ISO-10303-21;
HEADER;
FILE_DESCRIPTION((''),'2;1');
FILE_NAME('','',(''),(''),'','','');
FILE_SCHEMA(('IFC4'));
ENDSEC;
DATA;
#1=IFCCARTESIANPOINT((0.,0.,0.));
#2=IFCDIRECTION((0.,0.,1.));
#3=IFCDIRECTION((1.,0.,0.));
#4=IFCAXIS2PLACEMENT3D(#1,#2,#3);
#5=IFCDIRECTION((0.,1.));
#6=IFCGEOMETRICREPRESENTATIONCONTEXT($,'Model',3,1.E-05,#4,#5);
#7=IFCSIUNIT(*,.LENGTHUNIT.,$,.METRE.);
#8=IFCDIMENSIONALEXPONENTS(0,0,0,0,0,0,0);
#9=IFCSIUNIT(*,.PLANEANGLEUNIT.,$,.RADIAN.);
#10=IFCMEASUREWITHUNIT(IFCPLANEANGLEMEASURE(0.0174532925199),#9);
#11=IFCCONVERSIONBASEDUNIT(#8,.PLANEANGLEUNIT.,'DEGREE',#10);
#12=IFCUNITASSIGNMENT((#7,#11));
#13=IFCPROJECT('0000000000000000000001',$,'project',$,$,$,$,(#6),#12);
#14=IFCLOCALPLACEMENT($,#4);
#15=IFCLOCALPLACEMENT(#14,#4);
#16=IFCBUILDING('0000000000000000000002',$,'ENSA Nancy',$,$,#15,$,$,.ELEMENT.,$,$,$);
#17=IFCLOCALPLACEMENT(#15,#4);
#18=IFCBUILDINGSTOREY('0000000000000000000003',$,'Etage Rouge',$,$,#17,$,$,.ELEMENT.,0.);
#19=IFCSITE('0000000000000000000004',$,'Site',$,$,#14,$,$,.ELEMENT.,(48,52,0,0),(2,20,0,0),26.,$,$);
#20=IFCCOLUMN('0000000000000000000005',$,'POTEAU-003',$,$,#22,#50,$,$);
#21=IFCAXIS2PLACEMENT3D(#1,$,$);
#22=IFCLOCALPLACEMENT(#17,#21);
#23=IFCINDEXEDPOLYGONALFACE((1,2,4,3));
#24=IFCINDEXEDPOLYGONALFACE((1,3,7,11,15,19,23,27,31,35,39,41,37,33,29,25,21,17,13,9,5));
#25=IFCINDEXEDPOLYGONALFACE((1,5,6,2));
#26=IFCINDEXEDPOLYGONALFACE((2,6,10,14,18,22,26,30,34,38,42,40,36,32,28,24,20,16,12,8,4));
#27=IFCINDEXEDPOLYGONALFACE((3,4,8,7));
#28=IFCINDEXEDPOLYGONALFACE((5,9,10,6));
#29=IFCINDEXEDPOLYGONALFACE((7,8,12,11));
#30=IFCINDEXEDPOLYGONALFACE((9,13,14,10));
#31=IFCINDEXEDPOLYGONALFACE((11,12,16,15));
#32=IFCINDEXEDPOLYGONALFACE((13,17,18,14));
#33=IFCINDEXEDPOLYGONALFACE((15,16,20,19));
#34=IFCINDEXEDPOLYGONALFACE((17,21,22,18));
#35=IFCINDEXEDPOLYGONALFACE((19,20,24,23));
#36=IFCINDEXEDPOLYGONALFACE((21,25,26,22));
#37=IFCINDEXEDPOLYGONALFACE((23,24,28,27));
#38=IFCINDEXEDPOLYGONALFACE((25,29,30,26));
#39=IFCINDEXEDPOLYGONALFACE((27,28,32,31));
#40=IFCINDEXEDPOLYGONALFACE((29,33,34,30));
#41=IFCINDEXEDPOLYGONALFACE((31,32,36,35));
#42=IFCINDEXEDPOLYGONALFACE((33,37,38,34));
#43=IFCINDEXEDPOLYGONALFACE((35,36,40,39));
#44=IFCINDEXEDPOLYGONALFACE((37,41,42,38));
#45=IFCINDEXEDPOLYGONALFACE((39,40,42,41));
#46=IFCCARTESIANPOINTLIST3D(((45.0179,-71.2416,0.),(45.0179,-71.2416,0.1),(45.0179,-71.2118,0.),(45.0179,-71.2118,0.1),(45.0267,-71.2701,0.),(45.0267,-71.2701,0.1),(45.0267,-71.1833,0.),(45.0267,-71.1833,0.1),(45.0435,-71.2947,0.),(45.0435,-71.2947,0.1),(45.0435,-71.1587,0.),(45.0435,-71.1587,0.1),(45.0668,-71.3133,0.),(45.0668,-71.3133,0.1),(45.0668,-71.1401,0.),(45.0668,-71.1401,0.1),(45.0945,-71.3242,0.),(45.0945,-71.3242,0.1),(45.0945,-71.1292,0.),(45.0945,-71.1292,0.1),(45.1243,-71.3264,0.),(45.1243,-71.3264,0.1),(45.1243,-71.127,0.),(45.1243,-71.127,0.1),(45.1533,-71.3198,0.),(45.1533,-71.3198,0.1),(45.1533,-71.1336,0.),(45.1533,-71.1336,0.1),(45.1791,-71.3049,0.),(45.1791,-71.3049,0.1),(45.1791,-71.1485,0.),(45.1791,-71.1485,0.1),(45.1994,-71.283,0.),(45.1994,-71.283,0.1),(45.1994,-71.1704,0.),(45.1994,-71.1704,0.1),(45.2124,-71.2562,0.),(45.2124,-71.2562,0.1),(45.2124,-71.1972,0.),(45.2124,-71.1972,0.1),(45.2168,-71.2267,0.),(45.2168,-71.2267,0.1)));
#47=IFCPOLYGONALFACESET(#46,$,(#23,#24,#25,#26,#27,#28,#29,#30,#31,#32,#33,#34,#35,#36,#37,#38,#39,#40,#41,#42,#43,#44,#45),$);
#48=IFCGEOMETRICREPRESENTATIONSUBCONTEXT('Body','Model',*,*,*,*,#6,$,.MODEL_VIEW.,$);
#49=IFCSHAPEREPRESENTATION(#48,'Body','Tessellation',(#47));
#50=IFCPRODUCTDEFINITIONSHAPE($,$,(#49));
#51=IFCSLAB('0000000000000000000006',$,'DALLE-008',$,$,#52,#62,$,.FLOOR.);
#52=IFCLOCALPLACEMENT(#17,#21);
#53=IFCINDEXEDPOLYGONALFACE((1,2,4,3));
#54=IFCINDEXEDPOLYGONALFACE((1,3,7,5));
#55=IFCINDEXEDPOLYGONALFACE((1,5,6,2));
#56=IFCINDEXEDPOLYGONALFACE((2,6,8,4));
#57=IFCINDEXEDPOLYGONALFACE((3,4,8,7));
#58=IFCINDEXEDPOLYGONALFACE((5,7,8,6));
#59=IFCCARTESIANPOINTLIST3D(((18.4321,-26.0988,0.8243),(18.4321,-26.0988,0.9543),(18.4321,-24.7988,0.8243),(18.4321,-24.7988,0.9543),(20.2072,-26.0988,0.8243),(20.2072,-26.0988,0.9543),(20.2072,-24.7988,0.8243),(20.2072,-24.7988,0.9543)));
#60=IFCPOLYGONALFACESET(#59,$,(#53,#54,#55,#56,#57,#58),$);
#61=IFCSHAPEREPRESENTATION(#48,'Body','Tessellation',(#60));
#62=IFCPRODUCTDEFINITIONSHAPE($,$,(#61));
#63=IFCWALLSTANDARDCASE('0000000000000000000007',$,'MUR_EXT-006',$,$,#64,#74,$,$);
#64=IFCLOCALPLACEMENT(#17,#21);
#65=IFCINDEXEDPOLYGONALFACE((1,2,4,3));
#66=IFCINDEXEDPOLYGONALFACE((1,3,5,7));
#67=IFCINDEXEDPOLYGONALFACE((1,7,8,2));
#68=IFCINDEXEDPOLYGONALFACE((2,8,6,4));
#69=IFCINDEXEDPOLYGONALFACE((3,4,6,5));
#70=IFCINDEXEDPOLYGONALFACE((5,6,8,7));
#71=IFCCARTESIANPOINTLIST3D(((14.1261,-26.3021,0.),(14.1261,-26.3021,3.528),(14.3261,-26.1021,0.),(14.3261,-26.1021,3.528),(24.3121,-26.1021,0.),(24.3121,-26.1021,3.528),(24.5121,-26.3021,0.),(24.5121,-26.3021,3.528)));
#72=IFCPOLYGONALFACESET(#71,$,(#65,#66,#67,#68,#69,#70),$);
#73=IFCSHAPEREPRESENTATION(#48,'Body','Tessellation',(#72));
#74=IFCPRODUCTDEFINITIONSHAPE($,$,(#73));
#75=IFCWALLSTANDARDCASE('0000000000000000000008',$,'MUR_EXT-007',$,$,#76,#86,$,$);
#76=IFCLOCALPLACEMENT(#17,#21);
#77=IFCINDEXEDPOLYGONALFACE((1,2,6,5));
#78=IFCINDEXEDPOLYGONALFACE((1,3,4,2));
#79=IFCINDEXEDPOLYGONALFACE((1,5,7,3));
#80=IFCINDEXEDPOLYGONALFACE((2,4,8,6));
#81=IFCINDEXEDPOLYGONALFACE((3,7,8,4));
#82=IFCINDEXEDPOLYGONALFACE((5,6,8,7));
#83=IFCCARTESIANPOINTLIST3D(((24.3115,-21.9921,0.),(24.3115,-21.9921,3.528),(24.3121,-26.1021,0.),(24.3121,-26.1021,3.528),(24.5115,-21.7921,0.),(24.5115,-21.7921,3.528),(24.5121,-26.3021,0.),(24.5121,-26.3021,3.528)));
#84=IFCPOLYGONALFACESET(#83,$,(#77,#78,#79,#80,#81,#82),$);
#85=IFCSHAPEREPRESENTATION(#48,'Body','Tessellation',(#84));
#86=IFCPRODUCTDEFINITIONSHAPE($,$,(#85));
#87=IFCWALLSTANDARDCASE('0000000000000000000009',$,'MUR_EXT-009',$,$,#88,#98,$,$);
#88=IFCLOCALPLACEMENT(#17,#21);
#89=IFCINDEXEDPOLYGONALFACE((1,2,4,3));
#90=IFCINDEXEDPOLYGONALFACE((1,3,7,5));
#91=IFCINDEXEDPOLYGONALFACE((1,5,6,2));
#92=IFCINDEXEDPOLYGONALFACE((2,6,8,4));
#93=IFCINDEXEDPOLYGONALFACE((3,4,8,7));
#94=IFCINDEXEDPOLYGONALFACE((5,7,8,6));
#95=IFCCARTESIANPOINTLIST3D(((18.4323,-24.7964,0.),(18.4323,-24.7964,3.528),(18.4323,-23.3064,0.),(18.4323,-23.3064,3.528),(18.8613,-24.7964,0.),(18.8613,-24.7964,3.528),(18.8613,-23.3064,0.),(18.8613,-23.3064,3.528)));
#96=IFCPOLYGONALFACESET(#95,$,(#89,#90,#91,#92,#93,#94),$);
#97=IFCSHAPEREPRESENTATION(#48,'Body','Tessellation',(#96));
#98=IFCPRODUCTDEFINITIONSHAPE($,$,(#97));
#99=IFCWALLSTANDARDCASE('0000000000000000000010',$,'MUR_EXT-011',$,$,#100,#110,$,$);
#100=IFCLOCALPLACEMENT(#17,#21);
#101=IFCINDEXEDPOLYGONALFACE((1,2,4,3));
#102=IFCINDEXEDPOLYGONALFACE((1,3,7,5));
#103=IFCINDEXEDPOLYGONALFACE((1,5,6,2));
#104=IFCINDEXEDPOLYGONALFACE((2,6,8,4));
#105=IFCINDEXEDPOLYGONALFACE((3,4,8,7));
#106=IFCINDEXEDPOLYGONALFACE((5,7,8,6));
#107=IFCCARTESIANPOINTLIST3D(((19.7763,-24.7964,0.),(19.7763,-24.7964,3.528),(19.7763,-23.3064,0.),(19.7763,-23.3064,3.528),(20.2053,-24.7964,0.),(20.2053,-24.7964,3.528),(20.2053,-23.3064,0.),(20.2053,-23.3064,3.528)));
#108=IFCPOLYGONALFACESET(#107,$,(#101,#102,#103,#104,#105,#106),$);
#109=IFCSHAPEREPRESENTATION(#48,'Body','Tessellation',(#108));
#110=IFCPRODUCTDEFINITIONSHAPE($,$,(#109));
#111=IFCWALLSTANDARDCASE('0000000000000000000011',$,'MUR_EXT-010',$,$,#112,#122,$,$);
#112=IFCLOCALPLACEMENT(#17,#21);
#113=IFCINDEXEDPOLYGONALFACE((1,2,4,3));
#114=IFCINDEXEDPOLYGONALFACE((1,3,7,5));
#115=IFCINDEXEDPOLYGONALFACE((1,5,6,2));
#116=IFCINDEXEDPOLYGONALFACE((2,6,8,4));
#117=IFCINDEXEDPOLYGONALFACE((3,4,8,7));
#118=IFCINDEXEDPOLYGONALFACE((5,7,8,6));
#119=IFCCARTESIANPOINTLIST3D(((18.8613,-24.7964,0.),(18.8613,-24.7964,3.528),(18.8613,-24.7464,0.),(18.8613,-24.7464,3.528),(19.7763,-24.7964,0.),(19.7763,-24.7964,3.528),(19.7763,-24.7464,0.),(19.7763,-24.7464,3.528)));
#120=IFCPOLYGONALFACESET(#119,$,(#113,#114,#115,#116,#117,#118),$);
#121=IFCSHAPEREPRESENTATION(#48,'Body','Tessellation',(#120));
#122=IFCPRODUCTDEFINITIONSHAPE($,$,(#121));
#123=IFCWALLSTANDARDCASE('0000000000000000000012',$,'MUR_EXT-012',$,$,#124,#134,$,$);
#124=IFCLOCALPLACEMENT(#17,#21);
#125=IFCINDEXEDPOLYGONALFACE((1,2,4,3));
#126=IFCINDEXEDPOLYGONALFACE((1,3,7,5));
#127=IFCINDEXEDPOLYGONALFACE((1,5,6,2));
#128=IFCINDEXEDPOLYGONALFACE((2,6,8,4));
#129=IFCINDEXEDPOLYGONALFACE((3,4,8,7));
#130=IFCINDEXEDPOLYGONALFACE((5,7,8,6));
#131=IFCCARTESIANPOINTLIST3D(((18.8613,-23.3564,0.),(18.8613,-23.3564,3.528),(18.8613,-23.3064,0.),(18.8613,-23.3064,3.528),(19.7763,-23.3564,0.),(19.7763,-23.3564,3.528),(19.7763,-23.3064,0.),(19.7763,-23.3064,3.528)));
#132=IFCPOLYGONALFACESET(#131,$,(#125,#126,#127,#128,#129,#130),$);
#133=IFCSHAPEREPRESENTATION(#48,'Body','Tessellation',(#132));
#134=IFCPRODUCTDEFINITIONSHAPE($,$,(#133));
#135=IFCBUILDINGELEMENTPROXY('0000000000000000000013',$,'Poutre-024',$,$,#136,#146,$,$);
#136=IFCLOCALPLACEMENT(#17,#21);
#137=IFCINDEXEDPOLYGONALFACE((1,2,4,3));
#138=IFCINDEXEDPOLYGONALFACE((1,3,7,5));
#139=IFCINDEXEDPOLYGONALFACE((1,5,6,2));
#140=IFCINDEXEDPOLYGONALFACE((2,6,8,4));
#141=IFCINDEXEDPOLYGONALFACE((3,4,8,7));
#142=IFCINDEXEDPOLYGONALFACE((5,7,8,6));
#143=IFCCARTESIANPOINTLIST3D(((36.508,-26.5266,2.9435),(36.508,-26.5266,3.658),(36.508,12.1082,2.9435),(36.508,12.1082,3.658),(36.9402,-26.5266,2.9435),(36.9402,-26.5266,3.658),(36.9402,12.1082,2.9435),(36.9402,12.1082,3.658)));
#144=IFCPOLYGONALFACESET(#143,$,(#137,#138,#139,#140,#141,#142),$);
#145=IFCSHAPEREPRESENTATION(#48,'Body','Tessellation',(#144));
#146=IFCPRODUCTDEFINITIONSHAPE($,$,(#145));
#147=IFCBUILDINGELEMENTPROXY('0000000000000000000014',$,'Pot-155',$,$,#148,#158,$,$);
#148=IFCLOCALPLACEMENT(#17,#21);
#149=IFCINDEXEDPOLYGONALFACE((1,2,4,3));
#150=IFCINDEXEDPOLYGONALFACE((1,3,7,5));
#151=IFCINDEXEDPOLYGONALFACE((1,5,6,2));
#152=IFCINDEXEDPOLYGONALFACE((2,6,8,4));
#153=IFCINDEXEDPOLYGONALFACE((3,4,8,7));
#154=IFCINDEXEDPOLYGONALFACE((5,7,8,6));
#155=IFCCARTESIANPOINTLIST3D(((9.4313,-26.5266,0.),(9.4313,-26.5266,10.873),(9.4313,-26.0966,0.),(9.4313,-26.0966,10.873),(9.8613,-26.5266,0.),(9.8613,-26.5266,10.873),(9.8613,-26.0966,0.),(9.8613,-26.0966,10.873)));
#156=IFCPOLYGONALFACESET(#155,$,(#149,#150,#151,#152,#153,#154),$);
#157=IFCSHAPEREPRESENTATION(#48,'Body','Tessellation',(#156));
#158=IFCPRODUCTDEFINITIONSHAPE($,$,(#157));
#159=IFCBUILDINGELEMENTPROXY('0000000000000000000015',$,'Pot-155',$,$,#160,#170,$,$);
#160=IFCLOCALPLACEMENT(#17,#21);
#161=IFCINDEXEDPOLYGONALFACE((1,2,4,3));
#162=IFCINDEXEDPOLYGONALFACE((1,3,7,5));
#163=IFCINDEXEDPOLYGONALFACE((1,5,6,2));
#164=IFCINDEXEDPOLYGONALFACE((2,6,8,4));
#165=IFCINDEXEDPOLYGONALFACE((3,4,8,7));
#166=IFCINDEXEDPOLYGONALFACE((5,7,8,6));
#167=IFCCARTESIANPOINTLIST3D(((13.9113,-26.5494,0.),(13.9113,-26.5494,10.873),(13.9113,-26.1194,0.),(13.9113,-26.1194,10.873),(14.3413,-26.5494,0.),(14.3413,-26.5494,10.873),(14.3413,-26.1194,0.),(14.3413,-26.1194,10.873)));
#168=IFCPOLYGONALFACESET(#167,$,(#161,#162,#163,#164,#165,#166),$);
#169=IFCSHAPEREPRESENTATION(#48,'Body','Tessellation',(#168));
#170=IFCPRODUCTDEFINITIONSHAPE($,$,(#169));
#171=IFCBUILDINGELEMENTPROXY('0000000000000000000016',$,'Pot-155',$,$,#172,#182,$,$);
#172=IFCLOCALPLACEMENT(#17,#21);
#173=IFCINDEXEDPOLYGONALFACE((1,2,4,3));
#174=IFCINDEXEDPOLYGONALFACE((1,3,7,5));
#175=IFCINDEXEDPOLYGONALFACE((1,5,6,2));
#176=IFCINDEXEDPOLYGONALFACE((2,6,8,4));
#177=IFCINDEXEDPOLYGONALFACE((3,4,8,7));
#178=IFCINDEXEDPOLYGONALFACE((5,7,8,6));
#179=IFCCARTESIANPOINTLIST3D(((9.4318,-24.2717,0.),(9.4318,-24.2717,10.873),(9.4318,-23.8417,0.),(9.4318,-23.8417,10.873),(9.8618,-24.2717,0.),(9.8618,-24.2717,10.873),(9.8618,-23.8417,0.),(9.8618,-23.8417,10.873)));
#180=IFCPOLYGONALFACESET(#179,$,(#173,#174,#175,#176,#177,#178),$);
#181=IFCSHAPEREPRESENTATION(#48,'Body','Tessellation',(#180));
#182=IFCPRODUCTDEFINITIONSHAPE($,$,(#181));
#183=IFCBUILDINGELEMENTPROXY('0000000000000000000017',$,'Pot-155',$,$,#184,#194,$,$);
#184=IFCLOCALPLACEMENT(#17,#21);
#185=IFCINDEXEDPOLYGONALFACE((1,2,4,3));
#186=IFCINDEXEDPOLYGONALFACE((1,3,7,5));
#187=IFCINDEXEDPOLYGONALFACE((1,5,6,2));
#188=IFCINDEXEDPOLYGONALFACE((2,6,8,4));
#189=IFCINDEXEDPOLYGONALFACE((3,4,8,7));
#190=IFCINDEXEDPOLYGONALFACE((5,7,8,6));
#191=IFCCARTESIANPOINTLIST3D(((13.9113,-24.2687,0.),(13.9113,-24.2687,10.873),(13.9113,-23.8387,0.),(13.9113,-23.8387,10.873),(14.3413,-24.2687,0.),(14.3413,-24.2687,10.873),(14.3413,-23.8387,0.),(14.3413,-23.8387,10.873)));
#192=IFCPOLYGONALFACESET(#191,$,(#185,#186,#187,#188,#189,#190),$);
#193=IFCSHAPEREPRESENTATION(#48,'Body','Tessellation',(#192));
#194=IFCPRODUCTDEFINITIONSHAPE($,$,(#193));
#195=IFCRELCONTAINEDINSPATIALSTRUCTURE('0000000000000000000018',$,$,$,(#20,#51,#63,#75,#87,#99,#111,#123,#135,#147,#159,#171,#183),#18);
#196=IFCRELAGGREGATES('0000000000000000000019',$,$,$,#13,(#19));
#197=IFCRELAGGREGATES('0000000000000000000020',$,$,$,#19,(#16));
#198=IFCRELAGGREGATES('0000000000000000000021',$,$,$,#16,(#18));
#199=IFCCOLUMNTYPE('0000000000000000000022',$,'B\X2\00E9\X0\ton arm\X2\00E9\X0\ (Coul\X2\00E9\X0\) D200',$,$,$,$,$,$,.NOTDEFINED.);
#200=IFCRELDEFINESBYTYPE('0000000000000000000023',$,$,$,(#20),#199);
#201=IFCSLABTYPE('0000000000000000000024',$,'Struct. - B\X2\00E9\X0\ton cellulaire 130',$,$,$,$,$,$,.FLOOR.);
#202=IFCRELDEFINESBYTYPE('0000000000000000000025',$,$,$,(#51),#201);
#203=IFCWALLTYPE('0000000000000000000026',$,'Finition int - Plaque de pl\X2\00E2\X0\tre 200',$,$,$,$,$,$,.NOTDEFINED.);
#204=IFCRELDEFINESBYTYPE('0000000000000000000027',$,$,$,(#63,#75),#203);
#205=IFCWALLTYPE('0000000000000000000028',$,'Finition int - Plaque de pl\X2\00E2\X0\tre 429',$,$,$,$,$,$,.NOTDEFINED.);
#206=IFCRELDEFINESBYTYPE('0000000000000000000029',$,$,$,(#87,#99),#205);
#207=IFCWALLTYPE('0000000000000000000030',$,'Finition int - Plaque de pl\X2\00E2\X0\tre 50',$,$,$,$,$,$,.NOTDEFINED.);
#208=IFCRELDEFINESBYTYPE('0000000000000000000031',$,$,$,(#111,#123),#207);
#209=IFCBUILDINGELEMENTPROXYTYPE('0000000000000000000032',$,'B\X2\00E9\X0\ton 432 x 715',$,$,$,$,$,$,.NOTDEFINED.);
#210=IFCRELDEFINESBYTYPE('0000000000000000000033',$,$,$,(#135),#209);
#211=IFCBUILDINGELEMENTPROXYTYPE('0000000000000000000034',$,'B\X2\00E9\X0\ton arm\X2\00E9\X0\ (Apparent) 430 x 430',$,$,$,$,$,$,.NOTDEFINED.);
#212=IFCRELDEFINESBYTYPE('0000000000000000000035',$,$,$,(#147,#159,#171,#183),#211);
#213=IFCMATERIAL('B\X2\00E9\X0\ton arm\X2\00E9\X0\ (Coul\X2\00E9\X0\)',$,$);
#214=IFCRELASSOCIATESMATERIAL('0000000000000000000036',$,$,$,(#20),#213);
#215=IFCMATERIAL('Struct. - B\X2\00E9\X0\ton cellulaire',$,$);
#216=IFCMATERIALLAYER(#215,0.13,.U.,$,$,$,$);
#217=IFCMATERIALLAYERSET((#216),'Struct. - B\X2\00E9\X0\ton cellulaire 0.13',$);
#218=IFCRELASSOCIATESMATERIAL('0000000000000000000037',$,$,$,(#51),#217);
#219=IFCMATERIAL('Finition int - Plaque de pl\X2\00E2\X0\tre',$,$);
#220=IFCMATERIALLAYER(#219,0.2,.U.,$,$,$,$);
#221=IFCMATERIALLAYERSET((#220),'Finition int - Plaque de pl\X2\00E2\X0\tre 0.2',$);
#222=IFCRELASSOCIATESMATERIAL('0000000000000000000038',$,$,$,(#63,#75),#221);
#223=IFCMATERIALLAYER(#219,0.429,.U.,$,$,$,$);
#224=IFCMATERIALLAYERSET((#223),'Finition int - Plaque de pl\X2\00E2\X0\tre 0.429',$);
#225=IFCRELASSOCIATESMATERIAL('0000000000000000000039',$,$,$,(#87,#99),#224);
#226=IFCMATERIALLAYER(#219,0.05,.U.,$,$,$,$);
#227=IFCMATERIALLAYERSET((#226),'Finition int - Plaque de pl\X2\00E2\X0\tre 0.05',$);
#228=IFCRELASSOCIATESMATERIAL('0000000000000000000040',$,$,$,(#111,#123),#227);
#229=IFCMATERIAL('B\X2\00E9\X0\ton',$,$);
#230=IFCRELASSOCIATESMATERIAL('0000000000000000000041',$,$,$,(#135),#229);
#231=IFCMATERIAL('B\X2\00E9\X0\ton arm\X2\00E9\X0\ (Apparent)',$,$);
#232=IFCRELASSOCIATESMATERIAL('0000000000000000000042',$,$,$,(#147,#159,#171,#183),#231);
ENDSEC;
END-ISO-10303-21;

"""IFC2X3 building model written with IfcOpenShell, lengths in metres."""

from ifc_helpers import new_model, entity, si_unit, converted_unit, direction, frame, frame_2d, origin_with_axes, origin_2d_with_axis, place, context, subcontext, project, spatial, polyline, rectangle, circle, outline, extrude, material, layer, layer_set, layer_usage, type_object, element, save


model = new_model("IFC2X3")

# Units and contexts
model_context = context("Model", 3, precision=1e-05, world=origin_with_axes(), true_north=direction((0.0, 1.0)))
body_context = subcontext(model_context, "Body", "Model", "MODEL_VIEW")
ifc_project = project(units=[si_unit("LENGTHUNIT", "METRE"), converted_unit("PLANEANGLEUNIT", "DEGREE", entity("IfcPlaneAngleMeasure", 0.0174532925199), si_unit("PLANEANGLEUNIT", "RADIAN"), dimensions=[0, 0, 0, 0, 0, 0, 0])], contexts=[model_context])

# Site, building, storey
site_placement = place(None, origin_with_axes())
site = spatial("IfcSite", under=ifc_project, at=site_placement, Name="Site", CompositionType="ELEMENT", RefLatitude=(48, 52, 0, 0), RefLongitude=(2, 20, 0, 0), RefElevation=26.0)
building_placement = place(site_placement, origin_with_axes())
building = spatial("IfcBuilding", under=site, at=building_placement, Name="ENSA Nancy", CompositionType="ELEMENT")
storey_placement = place(building_placement, origin_with_axes())
storey = spatial("IfcBuildingStorey", under=building, at=storey_placement, Name="Etage Rouge", CompositionType="ELEMENT", Elevation=0.0)

# Column
ifc_material_1 = material(Name="Béton armé (Coulé)")
column_type = type_object("IfcColumnType", Name="Béton armé (Coulé) D200", PredefinedType="NOTDEFINED")
column_placement = place(storey_placement, frame((45.1168, -71.2267, 0.0), z_axis=(0.0, 0.0, 1.0), x_axis=(1.0, 0.0, 0.0)))
element("IfcColumn", 1, at=column_placement, inside=storey, type_object=column_type, material=ifc_material_1, Name="POTEAU-003", context=body_context, shape_type="SweptSolid", body=[
    extrude(circle(Radius=0.1, at=origin_2d_with_axis()), origin_with_axes(), (0.0, 0.0, 1.0), 0.1),
])

# Slab
ifc_material_2 = material(Name="Struct. - Béton cellulaire")
ifc_layer_1 = layer(ifc_material_2, 0.13, ventilated="UNKNOWN")
ifc_layer_set_1 = layer_set([ifc_layer_1], Name="Struct. - Béton cellulaire 0.13")
ifc_layer_usage_1 = layer_usage(ifc_layer_set_1, "AXIS3", "NEGATIVE", 0.13)
slab_type = type_object("IfcSlabType", Name="Struct. - Béton cellulaire 130", PredefinedType="FLOOR")
slab_placement = place(storey_placement, frame((18.4321, -26.0988, 0.9543), z_axis=(0.0, 0.0, 1.0), x_axis=(1.0, 0.0, 0.0)))
element("IfcSlab", 2, at=slab_placement, inside=storey, type_object=slab_type, material=ifc_layer_usage_1, Name="DALLE-008", PredefinedType="FLOOR", context=body_context, shape_type="SweptSolid", body=[
    extrude(outline(polyline([(0.0, 0.0), (1.7751, 0.0), (1.7751, 1.3), (0.0, 1.3), (0.0, 0.0)])), frame((0.0, 0.0, -0.13), z_axis=(0.0, 0.0, 1.0), x_axis=(1.0, 0.0, 0.0)), (0.0, 0.0, 1.0), 0.13),
])

# Walls
ifc_material_3 = material(Name="Finition int - Plaque de plâtre")
ifc_layer_2 = layer(ifc_material_3, 0.2, ventilated="UNKNOWN")
ifc_layer_set_2 = layer_set([ifc_layer_2], Name="Finition int - Plaque de plâtre 0.2")
ifc_layer_usage_2 = layer_usage(ifc_layer_set_2, "AXIS2", "POSITIVE", 0.0)
wall_type_1 = type_object("IfcWallType", Name="Finition int - Plaque de plâtre 200", PredefinedType="NOTDEFINED")
wall_1_placement = place(storey_placement, frame((14.1261, -26.3021, 0.0), z_axis=(0.0, 0.0, 1.0), x_axis=(1.0, 0.000003, 0.0)))
element("IfcWallStandardCase", 3, at=wall_1_placement, inside=storey, type_object=wall_type_1, material=ifc_layer_usage_2, Name="MUR_EXT-006", context=body_context, shape_type="SweptSolid", body=[
    extrude(outline(polyline([(0.0, 0.0), (10.386, 0.0), (10.186, 0.2), (0.2, 0.2), (0.0, 0.0)])), origin_with_axes(), (0.0, 0.0, 1.0), 3.528),
])
ifc_layer_usage_3 = layer_usage(ifc_layer_set_2, "AXIS2", "POSITIVE", 0.0)
wall_2_placement = place(storey_placement, frame((24.5121, -26.3021, 0.0), z_axis=(0.0, 0.0, 1.0), x_axis=(-0.00015, 1.0, 0.0)))
element("IfcWallStandardCase", 4, at=wall_2_placement, inside=storey, type_object=wall_type_1, material=ifc_layer_usage_3, Name="MUR_EXT-007", context=body_context, shape_type="SweptSolid", body=[
    extrude(outline(polyline([(0.0, 0.0), (4.51, 0.0), (4.31, 0.2), (0.2, 0.2), (0.0, 0.0)])), origin_with_axes(), (0.0, 0.0, 1.0), 3.528),
])
ifc_layer_3 = layer(ifc_material_3, 0.429, ventilated="UNKNOWN")
ifc_layer_set_3 = layer_set([ifc_layer_3], Name="Finition int - Plaque de plâtre 0.429")
ifc_layer_usage_4 = layer_usage(ifc_layer_set_3, "AXIS2", "POSITIVE", -0.429)
wall_type_2 = type_object("IfcWallType", Name="Finition int - Plaque de plâtre 429", PredefinedType="NOTDEFINED")
wall_3_placement = place(storey_placement, frame((18.8613, -23.3064, 0.0), z_axis=(0.0, 0.0, 1.0), x_axis=(0.0, -1.0, 0.0)))
element("IfcWallStandardCase", 5, at=wall_3_placement, inside=storey, type_object=wall_type_2, material=ifc_layer_usage_4, Name="MUR_EXT-009", context=body_context, shape_type="SweptSolid", body=[
    extrude(outline(polyline([(0.0, -0.429), (1.49, -0.429), (1.49, 0.0), (0.0, 0.0), (0.0, -0.429)])), origin_with_axes(), (0.0, 0.0, 1.0), 3.528),
])
ifc_layer_usage_5 = layer_usage(ifc_layer_set_3, "AXIS2", "POSITIVE", -0.429)
wall_4_placement = place(storey_placement, frame((19.7763, -24.7964, 0.0), z_axis=(0.0, 0.0, 1.0), x_axis=(0.0, 1.0, 0.0)))
element("IfcWallStandardCase", 6, at=wall_4_placement, inside=storey, type_object=wall_type_2, material=ifc_layer_usage_5, Name="MUR_EXT-011", context=body_context, shape_type="SweptSolid", body=[
    extrude(outline(polyline([(0.0, -0.429), (1.49, -0.429), (1.49, 0.0), (0.0, 0.0), (0.0, -0.429)])), origin_with_axes(), (0.0, 0.0, 1.0), 3.528),
])
ifc_layer_4 = layer(ifc_material_3, 0.05, ventilated="UNKNOWN")
ifc_layer_set_4 = layer_set([ifc_layer_4], Name="Finition int - Plaque de plâtre 0.05")
ifc_layer_usage_6 = layer_usage(ifc_layer_set_4, "AXIS2", "POSITIVE", -0.05)
wall_type_3 = type_object("IfcWallType", Name="Finition int - Plaque de plâtre 50", PredefinedType="NOTDEFINED")
wall_5_placement = place(storey_placement, frame((18.8613, -24.7464, 0.0), z_axis=(0.0, 0.0, 1.0), x_axis=(1.0, 0.0, 0.0)))
element("IfcWallStandardCase", 7, at=wall_5_placement, inside=storey, type_object=wall_type_3, material=ifc_layer_usage_6, Name="MUR_EXT-010", context=body_context, shape_type="SweptSolid", body=[
    extrude(outline(polyline([(0.0, -0.05), (0.915, -0.05), (0.915, 0.0), (0.0, 0.0), (0.0, -0.05)])), origin_with_axes(), (0.0, 0.0, 1.0), 3.528),
])
ifc_layer_usage_7 = layer_usage(ifc_layer_set_4, "AXIS2", "POSITIVE", -0.05)
wall_6_placement = place(storey_placement, frame((19.7763, -23.3564, 0.0), z_axis=(0.0, 0.0, 1.0), x_axis=(-1.0, 0.0, 0.0)))
element("IfcWallStandardCase", 8, at=wall_6_placement, inside=storey, type_object=wall_type_3, material=ifc_layer_usage_7, Name="MUR_EXT-012", context=body_context, shape_type="SweptSolid", body=[
    extrude(outline(polyline([(0.0, -0.05), (0.915, -0.05), (0.915, 0.0), (0.0, 0.0), (0.0, -0.05)])), origin_with_axes(), (0.0, 0.0, 1.0), 3.528),
])

# Building element proxies
ifc_material_4 = material(Name="Béton")
building_element_proxy_type_1 = type_object("IfcBuildingElementProxyType", Name="Béton 432 x 715", PredefinedType="NOTDEFINED")
proxy_1_placement = place(storey_placement, frame((36.7241, -26.5266, 3.658), z_axis=(0.0, 0.0, 1.0), x_axis=(1.0, 0.0, 0.0)))
element("IfcBuildingElementProxy", 9, at=proxy_1_placement, inside=storey, type_object=building_element_proxy_type_1, material=ifc_material_4, Name="Poutre-024", context=body_context, shape_type="SweptSolid", body=[
    extrude(rectangle(XDim=0.7145, YDim=0.4321, at=frame_2d((-0.3573, 0.0), x_axis=(1.0, 0.0))), frame((0.0, 0.0, 0.0), z_axis=(0.0, 1.0, 0.0), x_axis=(0.0, 0.0, 1.0)), (0.0, 0.0, 1.0), 38.6348),
])
ifc_material_5 = material(Name="Béton armé (Apparent)")
building_element_proxy_type_2 = type_object("IfcBuildingElementProxyType", Name="Béton armé (Apparent) 430 x 430", PredefinedType="NOTDEFINED")
for number, where, z_axis, x_axis, name in (
    (10, (9.6463, -26.3116, 0.0), (0.0, 0.0, 1.0), (1.0, 0.0, 0.0), "Pot-155"),
    (11, (14.1263, -26.3344, 0.0), (0.0, 0.0, 1.0), (1.0, 0.0, 0.0), "Pot-155"),
    (12, (9.6468, -24.0567, 0.0), (0.0, 0.0, 1.0), (1.0, 0.0, 0.0), "Pot-155"),
    (13, (14.1263, -24.0537, 0.0), (0.0, 0.0, 1.0), (1.0, 0.0, 0.0), "Pot-155"),
):
    element("IfcBuildingElementProxy", number, at=place(storey_placement, frame(where, z_axis=z_axis, x_axis=x_axis)), inside=storey, type_object=building_element_proxy_type_2, material=ifc_material_5, Name=name, context=body_context, shape_type="SweptSolid", body=[
        extrude(rectangle(XDim=0.43, YDim=0.43, at=origin_2d_with_axis()), origin_with_axes(), (0.0, 0.0, 1.0), 10.873),
    ])

save(model, "model.ifc")
